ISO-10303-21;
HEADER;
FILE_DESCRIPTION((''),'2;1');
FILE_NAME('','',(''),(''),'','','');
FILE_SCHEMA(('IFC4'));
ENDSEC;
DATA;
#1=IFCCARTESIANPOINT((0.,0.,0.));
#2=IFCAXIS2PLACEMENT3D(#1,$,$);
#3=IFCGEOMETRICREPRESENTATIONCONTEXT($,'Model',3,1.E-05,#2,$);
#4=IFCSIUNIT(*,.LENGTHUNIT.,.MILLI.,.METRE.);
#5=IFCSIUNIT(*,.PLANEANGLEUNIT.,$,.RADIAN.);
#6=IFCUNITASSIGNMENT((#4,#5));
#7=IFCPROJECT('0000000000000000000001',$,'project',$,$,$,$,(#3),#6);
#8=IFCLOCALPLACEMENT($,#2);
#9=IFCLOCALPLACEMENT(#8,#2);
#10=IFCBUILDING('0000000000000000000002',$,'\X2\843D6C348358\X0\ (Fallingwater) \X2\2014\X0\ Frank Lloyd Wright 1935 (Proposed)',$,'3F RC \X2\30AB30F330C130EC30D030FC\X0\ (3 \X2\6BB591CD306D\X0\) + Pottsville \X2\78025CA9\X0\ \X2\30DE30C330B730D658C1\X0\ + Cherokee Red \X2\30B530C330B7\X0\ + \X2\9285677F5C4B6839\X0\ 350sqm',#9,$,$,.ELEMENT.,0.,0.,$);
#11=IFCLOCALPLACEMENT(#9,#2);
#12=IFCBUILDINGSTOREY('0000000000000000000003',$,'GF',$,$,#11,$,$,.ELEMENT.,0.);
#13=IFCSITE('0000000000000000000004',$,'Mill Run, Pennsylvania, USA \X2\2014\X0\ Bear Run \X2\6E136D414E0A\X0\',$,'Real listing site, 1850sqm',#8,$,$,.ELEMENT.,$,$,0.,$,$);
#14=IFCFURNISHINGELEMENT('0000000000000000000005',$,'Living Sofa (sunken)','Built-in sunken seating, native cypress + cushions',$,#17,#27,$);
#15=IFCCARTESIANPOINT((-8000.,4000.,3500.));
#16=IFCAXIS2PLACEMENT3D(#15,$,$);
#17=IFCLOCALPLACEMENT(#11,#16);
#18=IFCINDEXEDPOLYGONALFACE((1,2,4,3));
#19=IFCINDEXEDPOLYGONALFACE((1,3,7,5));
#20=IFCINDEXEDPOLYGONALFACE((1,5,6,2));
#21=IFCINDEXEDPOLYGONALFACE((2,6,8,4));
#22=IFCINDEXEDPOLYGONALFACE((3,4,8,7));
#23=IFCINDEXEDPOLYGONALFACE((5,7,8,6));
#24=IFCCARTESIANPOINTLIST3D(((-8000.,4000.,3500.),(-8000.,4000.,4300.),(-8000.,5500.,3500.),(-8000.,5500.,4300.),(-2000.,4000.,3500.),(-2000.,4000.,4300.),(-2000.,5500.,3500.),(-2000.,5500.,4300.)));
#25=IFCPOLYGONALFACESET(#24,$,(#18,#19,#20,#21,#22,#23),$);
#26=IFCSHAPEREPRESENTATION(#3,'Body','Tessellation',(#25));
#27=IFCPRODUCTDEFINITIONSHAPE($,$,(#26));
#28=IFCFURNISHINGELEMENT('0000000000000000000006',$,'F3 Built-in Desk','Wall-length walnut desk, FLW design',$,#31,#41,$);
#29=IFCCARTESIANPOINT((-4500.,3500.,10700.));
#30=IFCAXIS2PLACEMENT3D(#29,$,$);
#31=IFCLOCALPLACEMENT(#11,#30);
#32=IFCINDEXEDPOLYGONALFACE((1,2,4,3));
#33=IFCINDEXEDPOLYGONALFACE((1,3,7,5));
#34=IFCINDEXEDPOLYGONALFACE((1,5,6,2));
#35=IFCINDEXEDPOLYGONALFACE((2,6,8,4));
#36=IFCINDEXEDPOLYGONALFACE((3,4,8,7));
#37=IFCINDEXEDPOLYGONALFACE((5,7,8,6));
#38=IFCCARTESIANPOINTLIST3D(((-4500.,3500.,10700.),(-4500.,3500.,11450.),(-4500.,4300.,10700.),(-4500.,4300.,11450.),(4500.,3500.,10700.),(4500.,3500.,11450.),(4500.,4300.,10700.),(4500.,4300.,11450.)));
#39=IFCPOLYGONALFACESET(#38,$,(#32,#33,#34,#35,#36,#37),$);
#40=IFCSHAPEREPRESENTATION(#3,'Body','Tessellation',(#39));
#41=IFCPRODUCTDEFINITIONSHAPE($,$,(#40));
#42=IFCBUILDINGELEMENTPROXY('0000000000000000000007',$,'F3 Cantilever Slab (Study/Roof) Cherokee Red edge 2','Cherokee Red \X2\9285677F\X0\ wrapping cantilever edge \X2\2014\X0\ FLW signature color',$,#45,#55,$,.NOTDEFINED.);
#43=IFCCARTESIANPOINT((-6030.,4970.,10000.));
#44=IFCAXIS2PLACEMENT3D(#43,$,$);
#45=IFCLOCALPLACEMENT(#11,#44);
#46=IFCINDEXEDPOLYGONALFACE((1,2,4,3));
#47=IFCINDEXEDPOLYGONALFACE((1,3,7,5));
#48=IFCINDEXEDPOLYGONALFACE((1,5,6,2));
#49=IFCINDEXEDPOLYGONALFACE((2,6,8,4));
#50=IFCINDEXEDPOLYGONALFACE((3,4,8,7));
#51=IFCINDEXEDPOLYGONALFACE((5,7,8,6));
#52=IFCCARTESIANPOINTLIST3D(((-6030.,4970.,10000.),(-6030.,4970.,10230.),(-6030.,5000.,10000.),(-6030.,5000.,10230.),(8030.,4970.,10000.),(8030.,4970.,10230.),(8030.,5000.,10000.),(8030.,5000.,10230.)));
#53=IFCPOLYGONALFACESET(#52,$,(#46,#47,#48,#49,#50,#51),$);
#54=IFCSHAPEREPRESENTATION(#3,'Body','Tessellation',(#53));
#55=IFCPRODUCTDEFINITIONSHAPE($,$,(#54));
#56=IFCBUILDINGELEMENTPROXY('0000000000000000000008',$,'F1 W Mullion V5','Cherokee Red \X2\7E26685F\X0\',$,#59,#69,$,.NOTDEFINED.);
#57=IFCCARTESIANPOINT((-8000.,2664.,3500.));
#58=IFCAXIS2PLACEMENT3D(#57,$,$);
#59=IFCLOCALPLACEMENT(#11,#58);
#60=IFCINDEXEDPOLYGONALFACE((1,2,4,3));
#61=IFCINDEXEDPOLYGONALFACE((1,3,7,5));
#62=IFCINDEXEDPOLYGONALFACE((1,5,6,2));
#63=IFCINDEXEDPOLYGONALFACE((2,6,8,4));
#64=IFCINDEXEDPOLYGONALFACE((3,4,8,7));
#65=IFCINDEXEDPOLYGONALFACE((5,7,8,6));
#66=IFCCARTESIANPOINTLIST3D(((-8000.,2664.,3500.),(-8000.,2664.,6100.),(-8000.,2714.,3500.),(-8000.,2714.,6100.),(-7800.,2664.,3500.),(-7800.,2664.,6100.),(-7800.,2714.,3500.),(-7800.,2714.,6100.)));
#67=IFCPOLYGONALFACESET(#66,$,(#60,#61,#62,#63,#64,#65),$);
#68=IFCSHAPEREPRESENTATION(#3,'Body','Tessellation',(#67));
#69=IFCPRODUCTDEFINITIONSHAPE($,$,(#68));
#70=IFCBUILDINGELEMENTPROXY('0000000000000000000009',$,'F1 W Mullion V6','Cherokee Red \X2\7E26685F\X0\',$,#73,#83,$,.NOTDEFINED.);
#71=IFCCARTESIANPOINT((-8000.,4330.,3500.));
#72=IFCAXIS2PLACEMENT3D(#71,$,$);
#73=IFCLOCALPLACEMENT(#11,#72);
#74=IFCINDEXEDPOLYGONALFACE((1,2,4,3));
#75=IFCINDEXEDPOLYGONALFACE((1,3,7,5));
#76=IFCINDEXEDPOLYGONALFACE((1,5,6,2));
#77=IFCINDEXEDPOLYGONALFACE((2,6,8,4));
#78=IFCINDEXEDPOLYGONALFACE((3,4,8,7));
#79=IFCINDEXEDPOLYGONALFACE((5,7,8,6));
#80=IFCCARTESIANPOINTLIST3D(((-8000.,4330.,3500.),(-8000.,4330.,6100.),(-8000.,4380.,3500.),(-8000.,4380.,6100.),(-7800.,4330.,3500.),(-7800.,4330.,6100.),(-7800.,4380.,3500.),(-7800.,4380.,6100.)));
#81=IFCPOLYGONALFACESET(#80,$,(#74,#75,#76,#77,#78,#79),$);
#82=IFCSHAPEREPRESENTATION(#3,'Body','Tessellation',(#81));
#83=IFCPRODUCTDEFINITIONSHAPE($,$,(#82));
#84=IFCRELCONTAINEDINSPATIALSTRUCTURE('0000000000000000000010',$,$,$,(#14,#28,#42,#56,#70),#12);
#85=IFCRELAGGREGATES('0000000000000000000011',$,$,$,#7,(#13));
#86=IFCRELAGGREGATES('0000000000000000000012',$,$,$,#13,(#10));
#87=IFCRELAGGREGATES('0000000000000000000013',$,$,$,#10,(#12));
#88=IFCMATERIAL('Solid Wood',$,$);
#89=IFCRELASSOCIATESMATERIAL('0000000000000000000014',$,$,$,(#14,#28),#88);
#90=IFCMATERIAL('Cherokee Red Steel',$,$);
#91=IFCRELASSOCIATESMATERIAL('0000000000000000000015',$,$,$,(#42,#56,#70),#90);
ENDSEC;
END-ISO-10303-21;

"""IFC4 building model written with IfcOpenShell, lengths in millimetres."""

from ifc_helpers import new_model, si_unit, frame, frame_2d, origin, place, context, project, spatial, rectangle, extrude, material, element, save


model = new_model("IFC4")

# Units and contexts
model_context = context("Model", 3, precision=1e-05, world=origin())
ifc_project = project(units=[si_unit("LENGTHUNIT", "METRE", prefix="MILLI"), si_unit("PLANEANGLEUNIT", "RADIAN")], contexts=[model_context])

# Site, building, storey
site_placement = place(None, origin())
site = spatial("IfcSite", under=ifc_project, at=site_placement, Name="Mill Run, Pennsylvania, USA — Bear Run 渓流上", ObjectType="Real listing site, 1850sqm", CompositionType="ELEMENT", RefElevation=0.0)
building_placement = place(site_placement, origin())
building = spatial("IfcBuilding", under=site, at=building_placement, Name="落水荘 (Fallingwater) — Frank Lloyd Wright 1935 (Proposed)", ObjectType="3F RC カンチレバー (3 段重ね) + Pottsville 砂岩 マッシブ壁 + Cherokee Red サッシ + 銅板屋根 350sqm", CompositionType="ELEMENT", ElevationOfRefHeight=0.0, ElevationOfTerrain=0.0)
storey_placement = place(building_placement, origin())
storey = spatial("IfcBuildingStorey", under=building, at=storey_placement, Name="GF", CompositionType="ELEMENT", Elevation=0.0)

# Shared definitions
ifc_material_1 = material(Name="Cherokee Red Steel")

# Furnishing elements
ifc_material_2 = material(Name="Solid Wood")
furnishing_1_placement = place(storey_placement, frame((-8000.0, 4000.0, 3500.0)))
element("IfcFurnishingElement", 1, at=furnishing_1_placement, inside=storey, material=ifc_material_2, Name="Living Sofa (sunken)", Description="Built-in sunken seating, native cypress + cushions", context=model_context, shape_type="SweptSolid", body=[
    extrude(rectangle(XDim=6000.0, YDim=1500.0, at=frame_2d((3000.0, 750.0))), frame((-8000.0, 4000.0, 3500.0)), (0.0, 0.0, 1.0), 800.0),
])
furnishing_2_placement = place(storey_placement, frame((-4500.0, 3500.0, 10700.0)))
element("IfcFurnishingElement", 2, at=furnishing_2_placement, inside=storey, material=ifc_material_2, Name="F3 Built-in Desk", Description="Wall-length walnut desk, FLW design", context=model_context, shape_type="SweptSolid", body=[
    extrude(rectangle(XDim=9000.0, YDim=800.0, at=frame_2d((4500.0, 400.0))), frame((-4500.0, 3500.0, 10700.0)), (0.0, 0.0, 1.0), 750.0),
])

# Building element proxies
proxy_1_placement = place(storey_placement, frame((-6030.0, 4970.0, 10000.0)))
element("IfcBuildingElementProxy", 3, at=proxy_1_placement, inside=storey, material=ifc_material_1, Name="F3 Cantilever Slab (Study/Roof) Cherokee Red edge 2", Description="Cherokee Red 銅板 wrapping cantilever edge — FLW signature color", PredefinedType="NOTDEFINED", context=model_context, shape_type="SweptSolid", body=[
    extrude(rectangle(XDim=14060.0, YDim=30.0, at=frame_2d((7030.0, 15.0))), frame((-6030.0, 4970.0, 10000.0)), (0.0, 0.0, 1.0), 230.0),
])
proxy_2_placement = place(storey_placement, frame((-8000.0, 2664.0, 3500.0)))
element("IfcBuildingElementProxy", 4, at=proxy_2_placement, inside=storey, material=ifc_material_1, Name="F1 W Mullion V5", Description="Cherokee Red 縦桟", PredefinedType="NOTDEFINED", context=model_context, shape_type="SweptSolid", body=[
    extrude(rectangle(XDim=200.0, YDim=50.0, at=frame_2d((100.0, 25.0))), frame((-8000.0, 2664.0, 3500.0)), (0.0, 0.0, 1.0), 2600.0),
])
proxy_3_placement = place(storey_placement, frame((-8000.0, 4330.0, 3500.0)))
element("IfcBuildingElementProxy", 5, at=proxy_3_placement, inside=storey, material=ifc_material_1, Name="F1 W Mullion V6", Description="Cherokee Red 縦桟", PredefinedType="NOTDEFINED", context=model_context, shape_type="SweptSolid", body=[
    extrude(rectangle(XDim=200.0, YDim=50.0, at=frame_2d((100.0, 25.0))), frame((-8000.0, 4330.0, 3500.0)), (0.0, 0.0, 1.0), 2600.0),
])

save(model, "model.ifc")
